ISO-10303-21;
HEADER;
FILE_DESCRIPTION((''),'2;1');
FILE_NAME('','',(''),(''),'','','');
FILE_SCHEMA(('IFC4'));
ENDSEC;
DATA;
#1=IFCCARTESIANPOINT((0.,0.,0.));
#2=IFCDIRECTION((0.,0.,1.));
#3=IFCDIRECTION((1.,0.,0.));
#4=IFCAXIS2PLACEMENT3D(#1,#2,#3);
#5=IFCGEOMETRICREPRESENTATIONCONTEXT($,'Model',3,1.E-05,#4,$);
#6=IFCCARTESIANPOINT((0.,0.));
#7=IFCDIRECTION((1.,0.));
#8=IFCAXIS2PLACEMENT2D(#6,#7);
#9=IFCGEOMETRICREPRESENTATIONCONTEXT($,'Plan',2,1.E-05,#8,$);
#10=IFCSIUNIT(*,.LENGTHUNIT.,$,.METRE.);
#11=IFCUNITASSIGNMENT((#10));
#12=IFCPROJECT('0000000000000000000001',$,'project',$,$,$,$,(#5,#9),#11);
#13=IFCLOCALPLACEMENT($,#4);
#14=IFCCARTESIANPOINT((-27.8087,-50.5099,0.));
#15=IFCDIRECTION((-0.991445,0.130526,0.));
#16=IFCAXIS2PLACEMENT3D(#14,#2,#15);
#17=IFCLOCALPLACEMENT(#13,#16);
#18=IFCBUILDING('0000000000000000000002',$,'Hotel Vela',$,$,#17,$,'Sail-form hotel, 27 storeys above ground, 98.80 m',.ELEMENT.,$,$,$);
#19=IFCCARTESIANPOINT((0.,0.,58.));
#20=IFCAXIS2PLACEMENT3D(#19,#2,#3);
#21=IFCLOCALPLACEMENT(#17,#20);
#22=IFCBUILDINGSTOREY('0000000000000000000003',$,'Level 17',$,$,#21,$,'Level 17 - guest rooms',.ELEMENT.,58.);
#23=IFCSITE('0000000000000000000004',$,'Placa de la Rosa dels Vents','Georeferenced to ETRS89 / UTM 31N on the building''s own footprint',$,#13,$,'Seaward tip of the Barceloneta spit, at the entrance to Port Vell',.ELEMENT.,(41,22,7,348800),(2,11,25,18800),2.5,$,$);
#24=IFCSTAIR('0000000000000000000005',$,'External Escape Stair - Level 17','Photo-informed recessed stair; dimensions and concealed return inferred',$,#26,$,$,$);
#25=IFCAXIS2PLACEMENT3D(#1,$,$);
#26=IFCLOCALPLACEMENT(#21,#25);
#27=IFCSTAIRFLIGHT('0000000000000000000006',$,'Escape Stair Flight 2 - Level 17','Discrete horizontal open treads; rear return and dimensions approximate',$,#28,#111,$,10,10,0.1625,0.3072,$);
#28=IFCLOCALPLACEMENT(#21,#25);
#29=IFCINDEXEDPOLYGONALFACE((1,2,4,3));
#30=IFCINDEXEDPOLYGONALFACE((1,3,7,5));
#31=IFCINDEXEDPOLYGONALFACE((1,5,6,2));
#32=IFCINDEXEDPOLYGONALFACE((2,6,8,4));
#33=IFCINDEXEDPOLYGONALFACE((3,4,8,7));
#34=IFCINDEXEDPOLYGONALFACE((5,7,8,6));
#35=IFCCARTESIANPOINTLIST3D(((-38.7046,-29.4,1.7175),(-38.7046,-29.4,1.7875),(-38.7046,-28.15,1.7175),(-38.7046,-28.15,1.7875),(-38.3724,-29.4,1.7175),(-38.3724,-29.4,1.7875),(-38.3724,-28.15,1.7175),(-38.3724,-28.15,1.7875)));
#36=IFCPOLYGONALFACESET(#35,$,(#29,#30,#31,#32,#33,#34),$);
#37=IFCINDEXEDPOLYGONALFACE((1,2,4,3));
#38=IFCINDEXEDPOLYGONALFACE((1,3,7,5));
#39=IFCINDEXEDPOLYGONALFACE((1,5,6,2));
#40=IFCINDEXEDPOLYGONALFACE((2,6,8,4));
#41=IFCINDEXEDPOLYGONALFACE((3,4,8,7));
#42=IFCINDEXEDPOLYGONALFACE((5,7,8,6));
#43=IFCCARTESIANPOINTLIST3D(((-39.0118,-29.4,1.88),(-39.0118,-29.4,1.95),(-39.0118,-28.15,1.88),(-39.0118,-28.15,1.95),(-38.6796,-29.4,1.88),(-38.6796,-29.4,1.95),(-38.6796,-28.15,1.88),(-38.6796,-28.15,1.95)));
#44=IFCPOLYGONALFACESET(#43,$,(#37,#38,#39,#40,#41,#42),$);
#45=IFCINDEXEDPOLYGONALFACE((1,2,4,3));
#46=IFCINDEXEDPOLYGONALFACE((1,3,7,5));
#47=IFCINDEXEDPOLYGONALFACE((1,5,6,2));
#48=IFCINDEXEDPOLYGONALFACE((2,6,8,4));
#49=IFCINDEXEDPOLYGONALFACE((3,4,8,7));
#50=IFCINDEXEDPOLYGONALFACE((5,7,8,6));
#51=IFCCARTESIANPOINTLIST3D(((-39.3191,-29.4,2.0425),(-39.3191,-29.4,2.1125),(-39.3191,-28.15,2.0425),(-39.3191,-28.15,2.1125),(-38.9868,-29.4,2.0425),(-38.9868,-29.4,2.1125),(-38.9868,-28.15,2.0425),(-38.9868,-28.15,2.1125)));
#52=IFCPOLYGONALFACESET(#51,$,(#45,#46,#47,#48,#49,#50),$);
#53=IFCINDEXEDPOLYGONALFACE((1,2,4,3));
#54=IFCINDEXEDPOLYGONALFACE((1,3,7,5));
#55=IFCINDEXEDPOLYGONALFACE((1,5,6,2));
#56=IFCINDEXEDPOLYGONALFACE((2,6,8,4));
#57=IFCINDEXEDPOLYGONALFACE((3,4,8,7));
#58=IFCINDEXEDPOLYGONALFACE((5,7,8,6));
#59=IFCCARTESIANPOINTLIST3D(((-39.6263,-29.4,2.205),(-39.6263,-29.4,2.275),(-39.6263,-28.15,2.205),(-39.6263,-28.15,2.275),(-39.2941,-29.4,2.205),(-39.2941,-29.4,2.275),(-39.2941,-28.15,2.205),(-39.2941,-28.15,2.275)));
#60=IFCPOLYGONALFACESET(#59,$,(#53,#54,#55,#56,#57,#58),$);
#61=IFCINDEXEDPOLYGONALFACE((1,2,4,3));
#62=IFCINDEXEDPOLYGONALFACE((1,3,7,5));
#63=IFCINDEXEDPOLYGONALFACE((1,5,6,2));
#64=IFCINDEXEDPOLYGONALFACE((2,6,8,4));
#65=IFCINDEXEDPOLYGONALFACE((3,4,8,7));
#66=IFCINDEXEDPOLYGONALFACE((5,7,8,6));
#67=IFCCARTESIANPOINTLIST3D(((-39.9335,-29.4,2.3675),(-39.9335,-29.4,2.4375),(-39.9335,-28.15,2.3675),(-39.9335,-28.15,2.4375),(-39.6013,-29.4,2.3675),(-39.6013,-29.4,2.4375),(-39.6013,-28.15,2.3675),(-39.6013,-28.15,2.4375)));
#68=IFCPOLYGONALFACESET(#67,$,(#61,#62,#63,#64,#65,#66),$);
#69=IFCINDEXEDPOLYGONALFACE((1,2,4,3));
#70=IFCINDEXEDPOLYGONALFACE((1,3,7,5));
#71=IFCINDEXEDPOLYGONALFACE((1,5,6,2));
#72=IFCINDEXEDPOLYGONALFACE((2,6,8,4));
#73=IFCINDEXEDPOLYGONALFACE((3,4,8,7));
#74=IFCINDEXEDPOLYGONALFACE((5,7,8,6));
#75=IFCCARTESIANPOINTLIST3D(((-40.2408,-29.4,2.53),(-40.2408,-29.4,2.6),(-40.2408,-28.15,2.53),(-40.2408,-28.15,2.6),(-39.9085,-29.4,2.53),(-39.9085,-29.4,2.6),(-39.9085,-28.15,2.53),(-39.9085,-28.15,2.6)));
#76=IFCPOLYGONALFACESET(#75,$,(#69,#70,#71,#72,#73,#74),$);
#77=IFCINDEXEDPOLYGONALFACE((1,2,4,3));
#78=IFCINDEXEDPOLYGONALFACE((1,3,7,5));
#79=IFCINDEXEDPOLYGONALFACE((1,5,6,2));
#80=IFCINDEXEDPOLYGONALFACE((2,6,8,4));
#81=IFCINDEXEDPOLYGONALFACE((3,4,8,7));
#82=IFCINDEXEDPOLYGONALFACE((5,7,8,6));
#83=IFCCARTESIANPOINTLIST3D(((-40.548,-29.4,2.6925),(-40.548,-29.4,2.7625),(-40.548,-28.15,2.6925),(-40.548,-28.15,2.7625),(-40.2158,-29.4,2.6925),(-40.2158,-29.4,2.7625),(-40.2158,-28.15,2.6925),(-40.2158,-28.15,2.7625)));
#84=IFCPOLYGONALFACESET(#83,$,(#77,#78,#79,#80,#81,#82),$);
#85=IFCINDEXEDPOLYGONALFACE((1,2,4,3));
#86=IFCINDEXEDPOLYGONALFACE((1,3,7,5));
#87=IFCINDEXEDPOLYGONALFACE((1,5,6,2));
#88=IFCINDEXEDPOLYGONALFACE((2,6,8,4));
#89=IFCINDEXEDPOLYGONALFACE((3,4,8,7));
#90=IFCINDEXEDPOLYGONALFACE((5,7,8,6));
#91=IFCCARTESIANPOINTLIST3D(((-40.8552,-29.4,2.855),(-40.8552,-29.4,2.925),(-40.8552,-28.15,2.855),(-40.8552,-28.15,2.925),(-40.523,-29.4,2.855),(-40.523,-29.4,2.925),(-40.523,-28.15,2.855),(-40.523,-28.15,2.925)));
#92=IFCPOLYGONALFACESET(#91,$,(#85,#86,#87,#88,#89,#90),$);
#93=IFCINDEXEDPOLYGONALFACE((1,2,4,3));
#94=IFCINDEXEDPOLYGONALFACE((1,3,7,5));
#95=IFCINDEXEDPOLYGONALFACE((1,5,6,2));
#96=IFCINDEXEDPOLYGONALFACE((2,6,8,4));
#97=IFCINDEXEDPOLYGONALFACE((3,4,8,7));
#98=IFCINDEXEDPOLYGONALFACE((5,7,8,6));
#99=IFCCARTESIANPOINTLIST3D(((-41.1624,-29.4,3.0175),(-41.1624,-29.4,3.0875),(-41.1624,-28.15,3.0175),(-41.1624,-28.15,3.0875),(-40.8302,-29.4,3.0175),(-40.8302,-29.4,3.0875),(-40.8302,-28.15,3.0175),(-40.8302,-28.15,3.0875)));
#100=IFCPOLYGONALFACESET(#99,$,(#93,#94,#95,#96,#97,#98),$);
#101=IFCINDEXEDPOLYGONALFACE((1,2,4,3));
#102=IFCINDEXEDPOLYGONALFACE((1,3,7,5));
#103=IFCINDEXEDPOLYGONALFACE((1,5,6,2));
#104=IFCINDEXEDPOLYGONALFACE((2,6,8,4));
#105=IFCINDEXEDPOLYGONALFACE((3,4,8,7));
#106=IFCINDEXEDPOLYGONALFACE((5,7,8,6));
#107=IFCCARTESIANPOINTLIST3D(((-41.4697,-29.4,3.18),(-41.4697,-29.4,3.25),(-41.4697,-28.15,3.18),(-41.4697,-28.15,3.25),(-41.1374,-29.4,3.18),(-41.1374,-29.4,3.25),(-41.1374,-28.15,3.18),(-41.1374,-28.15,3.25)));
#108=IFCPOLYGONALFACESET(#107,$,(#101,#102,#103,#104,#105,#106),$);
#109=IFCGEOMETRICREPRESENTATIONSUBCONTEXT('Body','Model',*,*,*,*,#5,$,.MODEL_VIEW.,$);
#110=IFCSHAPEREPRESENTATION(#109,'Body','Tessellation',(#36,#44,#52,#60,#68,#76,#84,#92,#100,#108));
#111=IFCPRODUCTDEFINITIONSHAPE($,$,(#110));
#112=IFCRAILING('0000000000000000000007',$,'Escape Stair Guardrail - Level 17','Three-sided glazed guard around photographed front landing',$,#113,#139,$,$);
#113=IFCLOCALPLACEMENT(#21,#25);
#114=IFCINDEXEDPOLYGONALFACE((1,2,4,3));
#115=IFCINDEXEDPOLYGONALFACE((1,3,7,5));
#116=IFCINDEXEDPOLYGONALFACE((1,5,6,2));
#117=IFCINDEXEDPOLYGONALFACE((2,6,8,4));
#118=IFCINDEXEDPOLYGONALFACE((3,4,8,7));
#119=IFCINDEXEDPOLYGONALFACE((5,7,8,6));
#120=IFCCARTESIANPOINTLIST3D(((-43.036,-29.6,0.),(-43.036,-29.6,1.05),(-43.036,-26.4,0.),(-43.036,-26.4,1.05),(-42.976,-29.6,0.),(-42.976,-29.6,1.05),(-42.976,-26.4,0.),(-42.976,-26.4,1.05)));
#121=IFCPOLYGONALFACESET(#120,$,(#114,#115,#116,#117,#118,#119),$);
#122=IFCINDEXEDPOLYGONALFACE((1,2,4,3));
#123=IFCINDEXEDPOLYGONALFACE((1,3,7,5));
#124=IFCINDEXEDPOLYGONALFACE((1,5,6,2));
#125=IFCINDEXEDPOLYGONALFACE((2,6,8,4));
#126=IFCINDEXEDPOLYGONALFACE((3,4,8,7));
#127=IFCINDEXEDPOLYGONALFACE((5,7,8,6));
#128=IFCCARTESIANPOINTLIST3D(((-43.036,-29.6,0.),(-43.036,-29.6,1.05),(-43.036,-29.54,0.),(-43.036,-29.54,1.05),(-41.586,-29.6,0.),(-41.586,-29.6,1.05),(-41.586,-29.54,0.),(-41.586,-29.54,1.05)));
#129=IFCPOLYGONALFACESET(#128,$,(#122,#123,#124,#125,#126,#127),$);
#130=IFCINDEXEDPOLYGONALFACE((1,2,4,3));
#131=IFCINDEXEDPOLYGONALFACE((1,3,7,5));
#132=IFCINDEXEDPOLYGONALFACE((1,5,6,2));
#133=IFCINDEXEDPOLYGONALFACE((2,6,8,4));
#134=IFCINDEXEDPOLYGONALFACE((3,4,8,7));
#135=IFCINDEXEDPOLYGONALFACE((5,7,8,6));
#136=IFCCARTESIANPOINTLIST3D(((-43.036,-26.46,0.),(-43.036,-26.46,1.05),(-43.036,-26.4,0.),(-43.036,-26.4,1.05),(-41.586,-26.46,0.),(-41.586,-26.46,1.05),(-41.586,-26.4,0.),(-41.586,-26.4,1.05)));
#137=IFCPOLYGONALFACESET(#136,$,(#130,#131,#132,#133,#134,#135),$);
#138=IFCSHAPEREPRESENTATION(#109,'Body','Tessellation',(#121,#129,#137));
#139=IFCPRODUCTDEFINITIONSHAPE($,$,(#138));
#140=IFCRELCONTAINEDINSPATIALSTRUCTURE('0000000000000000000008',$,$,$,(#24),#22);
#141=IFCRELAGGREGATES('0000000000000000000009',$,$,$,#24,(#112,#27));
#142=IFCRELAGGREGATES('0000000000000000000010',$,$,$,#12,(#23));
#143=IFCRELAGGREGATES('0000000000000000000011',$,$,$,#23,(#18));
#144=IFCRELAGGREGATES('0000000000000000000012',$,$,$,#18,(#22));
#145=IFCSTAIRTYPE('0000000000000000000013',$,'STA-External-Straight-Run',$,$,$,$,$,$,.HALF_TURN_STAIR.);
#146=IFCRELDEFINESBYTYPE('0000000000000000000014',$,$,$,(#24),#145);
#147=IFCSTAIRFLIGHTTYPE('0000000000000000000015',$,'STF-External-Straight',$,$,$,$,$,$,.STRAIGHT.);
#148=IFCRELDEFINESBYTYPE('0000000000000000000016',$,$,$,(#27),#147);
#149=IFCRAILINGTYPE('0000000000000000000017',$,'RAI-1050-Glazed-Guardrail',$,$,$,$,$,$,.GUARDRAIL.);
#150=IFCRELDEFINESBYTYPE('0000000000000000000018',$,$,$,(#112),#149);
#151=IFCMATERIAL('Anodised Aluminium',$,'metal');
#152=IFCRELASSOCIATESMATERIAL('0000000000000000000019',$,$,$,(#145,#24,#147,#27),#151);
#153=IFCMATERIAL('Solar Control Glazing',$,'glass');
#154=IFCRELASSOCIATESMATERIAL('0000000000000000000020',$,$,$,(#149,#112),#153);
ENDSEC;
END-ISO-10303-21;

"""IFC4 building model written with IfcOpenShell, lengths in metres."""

from ifc_helpers import new_model, si_unit, frame, origin_with_axes, origin_2d_with_axis, place, context, subcontext, project, spatial, line, indexed_curve, outline, extrude, material, type_object, element, aggregate, save


model = new_model("IFC4")

# Units and contexts
model_context = context("Model", 3, precision=1e-05, world=origin_with_axes())
plan_context = context("Plan", 2, precision=1e-05, world=origin_2d_with_axis())
body_context = subcontext(model_context, "Body", "Model", "MODEL_VIEW")
ifc_project = project(units=[si_unit("LENGTHUNIT", "METRE")], contexts=[model_context, plan_context])

# Site, building, storey
site_placement = place(None, origin_with_axes())
site = spatial("IfcSite", under=ifc_project, at=site_placement, Name="Placa de la Rosa dels Vents", Description="Georeferenced to ETRS89 / UTM 31N on the building's own footprint", LongName="Seaward tip of the Barceloneta spit, at the entrance to Port Vell", CompositionType="ELEMENT", RefLatitude=(41, 22, 7, 348800), RefLongitude=(2, 11, 25, 18800), RefElevation=2.5)
building_placement = place(site_placement, frame((-27.8087, -50.5099, 0.0), z_axis=(0.0, 0.0, 1.0), x_axis=(-0.991445, 0.130526, 0.0)))
building = spatial("IfcBuilding", under=site, at=building_placement, Name="Hotel Vela", LongName="Sail-form hotel, 27 storeys above ground, 98.80 m", CompositionType="ELEMENT")
storey_placement = place(building_placement, frame((0.0, 0.0, 58.0), z_axis=(0.0, 0.0, 1.0), x_axis=(1.0, 0.0, 0.0)))
storey = spatial("IfcBuildingStorey", under=building, at=storey_placement, Name="Level 17", LongName="Level 17 - guest rooms", CompositionType="ELEMENT", Elevation=58.0)

# Stair
ifc_material_1 = material(Name="Anodised Aluminium", Category="metal")
stair_type = type_object("IfcStairType", Name="STA-External-Straight-Run", PredefinedType="HALF_TURN_STAIR", material=ifc_material_1)
stair_placement = place(storey_placement, frame((0.0, 0.0, -58.0), z_axis=(0.0, 0.0, 1.0), x_axis=(1.0, 0.0, 0.0)))
stair = element("IfcStair", 1, at=stair_placement, inside=storey, type_object=stair_type, material=ifc_material_1, Name="External Escape Stair - Level 17", Description="Photo-informed recessed stair; dimensions and concealed return inferred")

# Stair flight
stair_flight_type = type_object("IfcStairFlightType", Name="STF-External-Straight", PredefinedType="STRAIGHT", material=ifc_material_1)
stair_flight_1_placement = place(stair_placement, origin_with_axes())
stair_flight_1 = element("IfcStairFlight", 2, at=stair_flight_1_placement, type_object=stair_flight_type, material=ifc_material_1, Name="Escape Stair Flight 2 - Level 17", Description="Discrete horizontal open treads; rear return and dimensions approximate", NumberOfRisers=10, NumberOfTreads=10, RiserHeight=0.1625, TreadLength=0.3072, context=body_context, shape_type="SweptSolid", body=[
    extrude(outline(indexed_curve([(0.0, 0.0), (0.3322, 0.0), (0.3322, 1.25), (0.0, 1.25)], segments=[line(1, 2, 3, 4, 1)])), frame((-38.7046, -29.4, 59.7175), z_axis=(0.0, 0.0, 1.0), x_axis=(1.0, 0.0, 0.0)), (0.0, 0.0, 1.0), 0.07),
    extrude(outline(indexed_curve([(0.0, 0.0), (0.3322, 0.0), (0.3322, 1.25), (0.0, 1.25)], segments=[line(1, 2, 3, 4, 1)])), frame((-39.0118, -29.4, 59.88), z_axis=(0.0, 0.0, 1.0), x_axis=(1.0, 0.0, 0.0)), (0.0, 0.0, 1.0), 0.07),
    extrude(outline(indexed_curve([(0.0, 0.0), (0.3322, 0.0), (0.3322, 1.25), (0.0, 1.25)], segments=[line(1, 2, 3, 4, 1)])), frame((-39.3191, -29.4, 60.0425), z_axis=(0.0, 0.0, 1.0), x_axis=(1.0, 0.0, 0.0)), (0.0, 0.0, 1.0), 0.07),
    extrude(outline(indexed_curve([(0.0, 0.0), (0.3322, 0.0), (0.3322, 1.25), (0.0, 1.25)], segments=[line(1, 2, 3, 4, 1)])), frame((-39.6263, -29.4, 60.205), z_axis=(0.0, 0.0, 1.0), x_axis=(1.0, 0.0, 0.0)), (0.0, 0.0, 1.0), 0.07),
    extrude(outline(indexed_curve([(0.0, 0.0), (0.3322, 0.0), (0.3322, 1.25), (0.0, 1.25)], segments=[line(1, 2, 3, 4, 1)])), frame((-39.9335, -29.4, 60.3675), z_axis=(0.0, 0.0, 1.0), x_axis=(1.0, 0.0, 0.0)), (0.0, 0.0, 1.0), 0.07),
    extrude(outline(indexed_curve([(0.0, 0.0), (0.3322, 0.0), (0.3322, 1.25), (0.0, 1.25)], segments=[line(1, 2, 3, 4, 1)])), frame((-40.2408, -29.4, 60.53), z_axis=(0.0, 0.0, 1.0), x_axis=(1.0, 0.0, 0.0)), (0.0, 0.0, 1.0), 0.07),
    extrude(outline(indexed_curve([(0.0, 0.0), (0.3322, 0.0), (0.3322, 1.25), (0.0, 1.25)], segments=[line(1, 2, 3, 4, 1)])), frame((-40.548, -29.4, 60.6925), z_axis=(0.0, 0.0, 1.0), x_axis=(1.0, 0.0, 0.0)), (0.0, 0.0, 1.0), 0.07),
    extrude(outline(indexed_curve([(0.0, 0.0), (0.3322, 0.0), (0.3322, 1.25), (0.0, 1.25)], segments=[line(1, 2, 3, 4, 1)])), frame((-40.8552, -29.4, 60.855), z_axis=(0.0, 0.0, 1.0), x_axis=(1.0, 0.0, 0.0)), (0.0, 0.0, 1.0), 0.07),
    extrude(outline(indexed_curve([(0.0, 0.0), (0.3322, 0.0), (0.3322, 1.25), (0.0, 1.25)], segments=[line(1, 2, 3, 4, 1)])), frame((-41.1624, -29.4, 61.0175), z_axis=(0.0, 0.0, 1.0), x_axis=(1.0, 0.0, 0.0)), (0.0, 0.0, 1.0), 0.07),
    extrude(outline(indexed_curve([(0.0, 0.0), (0.3322, 0.0), (0.3322, 1.25), (0.0, 1.25)], segments=[line(1, 2, 3, 4, 1)])), frame((-41.4697, -29.4, 61.18), z_axis=(0.0, 0.0, 1.0), x_axis=(1.0, 0.0, 0.0)), (0.0, 0.0, 1.0), 0.07),
])

# Railing
ifc_material_2 = material(Name="Solar Control Glazing", Category="glass")
railing_type = type_object("IfcRailingType", Name="RAI-1050-Glazed-Guardrail", PredefinedType="GUARDRAIL", material=ifc_material_2)
railing_placement = place(stair_placement, origin_with_axes())
railing = element("IfcRailing", 3, at=railing_placement, type_object=railing_type, material=ifc_material_2, Name="Escape Stair Guardrail - Level 17", Description="Three-sided glazed guard around photographed front landing", context=body_context, shape_type="SweptSolid", body=[
    extrude(outline(indexed_curve([(0.0, 0.0), (0.06, 0.0), (0.06, 3.2), (0.0, 3.2)], segments=[line(1, 2, 3, 4, 1)])), frame((-43.036, -29.6, 58.0), z_axis=(0.0, 0.0, 1.0), x_axis=(1.0, 0.0, 0.0)), (0.0, 0.0, 1.0), 1.05),
    extrude(outline(indexed_curve([(0.0, 0.0), (1.45, 0.0), (1.45, 0.06), (0.0, 0.06)], segments=[line(1, 2, 3, 4, 1)])), frame((-43.036, -29.6, 58.0), z_axis=(0.0, 0.0, 1.0), x_axis=(1.0, 0.0, 0.0)), (0.0, 0.0, 1.0), 1.05),
    extrude(outline(indexed_curve([(0.0, 0.0), (1.45, 0.0), (1.45, 0.06), (0.0, 0.06)], segments=[line(1, 2, 3, 4, 1)])), frame((-43.036, -26.46, 58.0), z_axis=(0.0, 0.0, 1.0), x_axis=(1.0, 0.0, 0.0)), (0.0, 0.0, 1.0), 1.05),
])
aggregate(stair, [railing, stair_flight_1])

save(model, "model.ifc")
